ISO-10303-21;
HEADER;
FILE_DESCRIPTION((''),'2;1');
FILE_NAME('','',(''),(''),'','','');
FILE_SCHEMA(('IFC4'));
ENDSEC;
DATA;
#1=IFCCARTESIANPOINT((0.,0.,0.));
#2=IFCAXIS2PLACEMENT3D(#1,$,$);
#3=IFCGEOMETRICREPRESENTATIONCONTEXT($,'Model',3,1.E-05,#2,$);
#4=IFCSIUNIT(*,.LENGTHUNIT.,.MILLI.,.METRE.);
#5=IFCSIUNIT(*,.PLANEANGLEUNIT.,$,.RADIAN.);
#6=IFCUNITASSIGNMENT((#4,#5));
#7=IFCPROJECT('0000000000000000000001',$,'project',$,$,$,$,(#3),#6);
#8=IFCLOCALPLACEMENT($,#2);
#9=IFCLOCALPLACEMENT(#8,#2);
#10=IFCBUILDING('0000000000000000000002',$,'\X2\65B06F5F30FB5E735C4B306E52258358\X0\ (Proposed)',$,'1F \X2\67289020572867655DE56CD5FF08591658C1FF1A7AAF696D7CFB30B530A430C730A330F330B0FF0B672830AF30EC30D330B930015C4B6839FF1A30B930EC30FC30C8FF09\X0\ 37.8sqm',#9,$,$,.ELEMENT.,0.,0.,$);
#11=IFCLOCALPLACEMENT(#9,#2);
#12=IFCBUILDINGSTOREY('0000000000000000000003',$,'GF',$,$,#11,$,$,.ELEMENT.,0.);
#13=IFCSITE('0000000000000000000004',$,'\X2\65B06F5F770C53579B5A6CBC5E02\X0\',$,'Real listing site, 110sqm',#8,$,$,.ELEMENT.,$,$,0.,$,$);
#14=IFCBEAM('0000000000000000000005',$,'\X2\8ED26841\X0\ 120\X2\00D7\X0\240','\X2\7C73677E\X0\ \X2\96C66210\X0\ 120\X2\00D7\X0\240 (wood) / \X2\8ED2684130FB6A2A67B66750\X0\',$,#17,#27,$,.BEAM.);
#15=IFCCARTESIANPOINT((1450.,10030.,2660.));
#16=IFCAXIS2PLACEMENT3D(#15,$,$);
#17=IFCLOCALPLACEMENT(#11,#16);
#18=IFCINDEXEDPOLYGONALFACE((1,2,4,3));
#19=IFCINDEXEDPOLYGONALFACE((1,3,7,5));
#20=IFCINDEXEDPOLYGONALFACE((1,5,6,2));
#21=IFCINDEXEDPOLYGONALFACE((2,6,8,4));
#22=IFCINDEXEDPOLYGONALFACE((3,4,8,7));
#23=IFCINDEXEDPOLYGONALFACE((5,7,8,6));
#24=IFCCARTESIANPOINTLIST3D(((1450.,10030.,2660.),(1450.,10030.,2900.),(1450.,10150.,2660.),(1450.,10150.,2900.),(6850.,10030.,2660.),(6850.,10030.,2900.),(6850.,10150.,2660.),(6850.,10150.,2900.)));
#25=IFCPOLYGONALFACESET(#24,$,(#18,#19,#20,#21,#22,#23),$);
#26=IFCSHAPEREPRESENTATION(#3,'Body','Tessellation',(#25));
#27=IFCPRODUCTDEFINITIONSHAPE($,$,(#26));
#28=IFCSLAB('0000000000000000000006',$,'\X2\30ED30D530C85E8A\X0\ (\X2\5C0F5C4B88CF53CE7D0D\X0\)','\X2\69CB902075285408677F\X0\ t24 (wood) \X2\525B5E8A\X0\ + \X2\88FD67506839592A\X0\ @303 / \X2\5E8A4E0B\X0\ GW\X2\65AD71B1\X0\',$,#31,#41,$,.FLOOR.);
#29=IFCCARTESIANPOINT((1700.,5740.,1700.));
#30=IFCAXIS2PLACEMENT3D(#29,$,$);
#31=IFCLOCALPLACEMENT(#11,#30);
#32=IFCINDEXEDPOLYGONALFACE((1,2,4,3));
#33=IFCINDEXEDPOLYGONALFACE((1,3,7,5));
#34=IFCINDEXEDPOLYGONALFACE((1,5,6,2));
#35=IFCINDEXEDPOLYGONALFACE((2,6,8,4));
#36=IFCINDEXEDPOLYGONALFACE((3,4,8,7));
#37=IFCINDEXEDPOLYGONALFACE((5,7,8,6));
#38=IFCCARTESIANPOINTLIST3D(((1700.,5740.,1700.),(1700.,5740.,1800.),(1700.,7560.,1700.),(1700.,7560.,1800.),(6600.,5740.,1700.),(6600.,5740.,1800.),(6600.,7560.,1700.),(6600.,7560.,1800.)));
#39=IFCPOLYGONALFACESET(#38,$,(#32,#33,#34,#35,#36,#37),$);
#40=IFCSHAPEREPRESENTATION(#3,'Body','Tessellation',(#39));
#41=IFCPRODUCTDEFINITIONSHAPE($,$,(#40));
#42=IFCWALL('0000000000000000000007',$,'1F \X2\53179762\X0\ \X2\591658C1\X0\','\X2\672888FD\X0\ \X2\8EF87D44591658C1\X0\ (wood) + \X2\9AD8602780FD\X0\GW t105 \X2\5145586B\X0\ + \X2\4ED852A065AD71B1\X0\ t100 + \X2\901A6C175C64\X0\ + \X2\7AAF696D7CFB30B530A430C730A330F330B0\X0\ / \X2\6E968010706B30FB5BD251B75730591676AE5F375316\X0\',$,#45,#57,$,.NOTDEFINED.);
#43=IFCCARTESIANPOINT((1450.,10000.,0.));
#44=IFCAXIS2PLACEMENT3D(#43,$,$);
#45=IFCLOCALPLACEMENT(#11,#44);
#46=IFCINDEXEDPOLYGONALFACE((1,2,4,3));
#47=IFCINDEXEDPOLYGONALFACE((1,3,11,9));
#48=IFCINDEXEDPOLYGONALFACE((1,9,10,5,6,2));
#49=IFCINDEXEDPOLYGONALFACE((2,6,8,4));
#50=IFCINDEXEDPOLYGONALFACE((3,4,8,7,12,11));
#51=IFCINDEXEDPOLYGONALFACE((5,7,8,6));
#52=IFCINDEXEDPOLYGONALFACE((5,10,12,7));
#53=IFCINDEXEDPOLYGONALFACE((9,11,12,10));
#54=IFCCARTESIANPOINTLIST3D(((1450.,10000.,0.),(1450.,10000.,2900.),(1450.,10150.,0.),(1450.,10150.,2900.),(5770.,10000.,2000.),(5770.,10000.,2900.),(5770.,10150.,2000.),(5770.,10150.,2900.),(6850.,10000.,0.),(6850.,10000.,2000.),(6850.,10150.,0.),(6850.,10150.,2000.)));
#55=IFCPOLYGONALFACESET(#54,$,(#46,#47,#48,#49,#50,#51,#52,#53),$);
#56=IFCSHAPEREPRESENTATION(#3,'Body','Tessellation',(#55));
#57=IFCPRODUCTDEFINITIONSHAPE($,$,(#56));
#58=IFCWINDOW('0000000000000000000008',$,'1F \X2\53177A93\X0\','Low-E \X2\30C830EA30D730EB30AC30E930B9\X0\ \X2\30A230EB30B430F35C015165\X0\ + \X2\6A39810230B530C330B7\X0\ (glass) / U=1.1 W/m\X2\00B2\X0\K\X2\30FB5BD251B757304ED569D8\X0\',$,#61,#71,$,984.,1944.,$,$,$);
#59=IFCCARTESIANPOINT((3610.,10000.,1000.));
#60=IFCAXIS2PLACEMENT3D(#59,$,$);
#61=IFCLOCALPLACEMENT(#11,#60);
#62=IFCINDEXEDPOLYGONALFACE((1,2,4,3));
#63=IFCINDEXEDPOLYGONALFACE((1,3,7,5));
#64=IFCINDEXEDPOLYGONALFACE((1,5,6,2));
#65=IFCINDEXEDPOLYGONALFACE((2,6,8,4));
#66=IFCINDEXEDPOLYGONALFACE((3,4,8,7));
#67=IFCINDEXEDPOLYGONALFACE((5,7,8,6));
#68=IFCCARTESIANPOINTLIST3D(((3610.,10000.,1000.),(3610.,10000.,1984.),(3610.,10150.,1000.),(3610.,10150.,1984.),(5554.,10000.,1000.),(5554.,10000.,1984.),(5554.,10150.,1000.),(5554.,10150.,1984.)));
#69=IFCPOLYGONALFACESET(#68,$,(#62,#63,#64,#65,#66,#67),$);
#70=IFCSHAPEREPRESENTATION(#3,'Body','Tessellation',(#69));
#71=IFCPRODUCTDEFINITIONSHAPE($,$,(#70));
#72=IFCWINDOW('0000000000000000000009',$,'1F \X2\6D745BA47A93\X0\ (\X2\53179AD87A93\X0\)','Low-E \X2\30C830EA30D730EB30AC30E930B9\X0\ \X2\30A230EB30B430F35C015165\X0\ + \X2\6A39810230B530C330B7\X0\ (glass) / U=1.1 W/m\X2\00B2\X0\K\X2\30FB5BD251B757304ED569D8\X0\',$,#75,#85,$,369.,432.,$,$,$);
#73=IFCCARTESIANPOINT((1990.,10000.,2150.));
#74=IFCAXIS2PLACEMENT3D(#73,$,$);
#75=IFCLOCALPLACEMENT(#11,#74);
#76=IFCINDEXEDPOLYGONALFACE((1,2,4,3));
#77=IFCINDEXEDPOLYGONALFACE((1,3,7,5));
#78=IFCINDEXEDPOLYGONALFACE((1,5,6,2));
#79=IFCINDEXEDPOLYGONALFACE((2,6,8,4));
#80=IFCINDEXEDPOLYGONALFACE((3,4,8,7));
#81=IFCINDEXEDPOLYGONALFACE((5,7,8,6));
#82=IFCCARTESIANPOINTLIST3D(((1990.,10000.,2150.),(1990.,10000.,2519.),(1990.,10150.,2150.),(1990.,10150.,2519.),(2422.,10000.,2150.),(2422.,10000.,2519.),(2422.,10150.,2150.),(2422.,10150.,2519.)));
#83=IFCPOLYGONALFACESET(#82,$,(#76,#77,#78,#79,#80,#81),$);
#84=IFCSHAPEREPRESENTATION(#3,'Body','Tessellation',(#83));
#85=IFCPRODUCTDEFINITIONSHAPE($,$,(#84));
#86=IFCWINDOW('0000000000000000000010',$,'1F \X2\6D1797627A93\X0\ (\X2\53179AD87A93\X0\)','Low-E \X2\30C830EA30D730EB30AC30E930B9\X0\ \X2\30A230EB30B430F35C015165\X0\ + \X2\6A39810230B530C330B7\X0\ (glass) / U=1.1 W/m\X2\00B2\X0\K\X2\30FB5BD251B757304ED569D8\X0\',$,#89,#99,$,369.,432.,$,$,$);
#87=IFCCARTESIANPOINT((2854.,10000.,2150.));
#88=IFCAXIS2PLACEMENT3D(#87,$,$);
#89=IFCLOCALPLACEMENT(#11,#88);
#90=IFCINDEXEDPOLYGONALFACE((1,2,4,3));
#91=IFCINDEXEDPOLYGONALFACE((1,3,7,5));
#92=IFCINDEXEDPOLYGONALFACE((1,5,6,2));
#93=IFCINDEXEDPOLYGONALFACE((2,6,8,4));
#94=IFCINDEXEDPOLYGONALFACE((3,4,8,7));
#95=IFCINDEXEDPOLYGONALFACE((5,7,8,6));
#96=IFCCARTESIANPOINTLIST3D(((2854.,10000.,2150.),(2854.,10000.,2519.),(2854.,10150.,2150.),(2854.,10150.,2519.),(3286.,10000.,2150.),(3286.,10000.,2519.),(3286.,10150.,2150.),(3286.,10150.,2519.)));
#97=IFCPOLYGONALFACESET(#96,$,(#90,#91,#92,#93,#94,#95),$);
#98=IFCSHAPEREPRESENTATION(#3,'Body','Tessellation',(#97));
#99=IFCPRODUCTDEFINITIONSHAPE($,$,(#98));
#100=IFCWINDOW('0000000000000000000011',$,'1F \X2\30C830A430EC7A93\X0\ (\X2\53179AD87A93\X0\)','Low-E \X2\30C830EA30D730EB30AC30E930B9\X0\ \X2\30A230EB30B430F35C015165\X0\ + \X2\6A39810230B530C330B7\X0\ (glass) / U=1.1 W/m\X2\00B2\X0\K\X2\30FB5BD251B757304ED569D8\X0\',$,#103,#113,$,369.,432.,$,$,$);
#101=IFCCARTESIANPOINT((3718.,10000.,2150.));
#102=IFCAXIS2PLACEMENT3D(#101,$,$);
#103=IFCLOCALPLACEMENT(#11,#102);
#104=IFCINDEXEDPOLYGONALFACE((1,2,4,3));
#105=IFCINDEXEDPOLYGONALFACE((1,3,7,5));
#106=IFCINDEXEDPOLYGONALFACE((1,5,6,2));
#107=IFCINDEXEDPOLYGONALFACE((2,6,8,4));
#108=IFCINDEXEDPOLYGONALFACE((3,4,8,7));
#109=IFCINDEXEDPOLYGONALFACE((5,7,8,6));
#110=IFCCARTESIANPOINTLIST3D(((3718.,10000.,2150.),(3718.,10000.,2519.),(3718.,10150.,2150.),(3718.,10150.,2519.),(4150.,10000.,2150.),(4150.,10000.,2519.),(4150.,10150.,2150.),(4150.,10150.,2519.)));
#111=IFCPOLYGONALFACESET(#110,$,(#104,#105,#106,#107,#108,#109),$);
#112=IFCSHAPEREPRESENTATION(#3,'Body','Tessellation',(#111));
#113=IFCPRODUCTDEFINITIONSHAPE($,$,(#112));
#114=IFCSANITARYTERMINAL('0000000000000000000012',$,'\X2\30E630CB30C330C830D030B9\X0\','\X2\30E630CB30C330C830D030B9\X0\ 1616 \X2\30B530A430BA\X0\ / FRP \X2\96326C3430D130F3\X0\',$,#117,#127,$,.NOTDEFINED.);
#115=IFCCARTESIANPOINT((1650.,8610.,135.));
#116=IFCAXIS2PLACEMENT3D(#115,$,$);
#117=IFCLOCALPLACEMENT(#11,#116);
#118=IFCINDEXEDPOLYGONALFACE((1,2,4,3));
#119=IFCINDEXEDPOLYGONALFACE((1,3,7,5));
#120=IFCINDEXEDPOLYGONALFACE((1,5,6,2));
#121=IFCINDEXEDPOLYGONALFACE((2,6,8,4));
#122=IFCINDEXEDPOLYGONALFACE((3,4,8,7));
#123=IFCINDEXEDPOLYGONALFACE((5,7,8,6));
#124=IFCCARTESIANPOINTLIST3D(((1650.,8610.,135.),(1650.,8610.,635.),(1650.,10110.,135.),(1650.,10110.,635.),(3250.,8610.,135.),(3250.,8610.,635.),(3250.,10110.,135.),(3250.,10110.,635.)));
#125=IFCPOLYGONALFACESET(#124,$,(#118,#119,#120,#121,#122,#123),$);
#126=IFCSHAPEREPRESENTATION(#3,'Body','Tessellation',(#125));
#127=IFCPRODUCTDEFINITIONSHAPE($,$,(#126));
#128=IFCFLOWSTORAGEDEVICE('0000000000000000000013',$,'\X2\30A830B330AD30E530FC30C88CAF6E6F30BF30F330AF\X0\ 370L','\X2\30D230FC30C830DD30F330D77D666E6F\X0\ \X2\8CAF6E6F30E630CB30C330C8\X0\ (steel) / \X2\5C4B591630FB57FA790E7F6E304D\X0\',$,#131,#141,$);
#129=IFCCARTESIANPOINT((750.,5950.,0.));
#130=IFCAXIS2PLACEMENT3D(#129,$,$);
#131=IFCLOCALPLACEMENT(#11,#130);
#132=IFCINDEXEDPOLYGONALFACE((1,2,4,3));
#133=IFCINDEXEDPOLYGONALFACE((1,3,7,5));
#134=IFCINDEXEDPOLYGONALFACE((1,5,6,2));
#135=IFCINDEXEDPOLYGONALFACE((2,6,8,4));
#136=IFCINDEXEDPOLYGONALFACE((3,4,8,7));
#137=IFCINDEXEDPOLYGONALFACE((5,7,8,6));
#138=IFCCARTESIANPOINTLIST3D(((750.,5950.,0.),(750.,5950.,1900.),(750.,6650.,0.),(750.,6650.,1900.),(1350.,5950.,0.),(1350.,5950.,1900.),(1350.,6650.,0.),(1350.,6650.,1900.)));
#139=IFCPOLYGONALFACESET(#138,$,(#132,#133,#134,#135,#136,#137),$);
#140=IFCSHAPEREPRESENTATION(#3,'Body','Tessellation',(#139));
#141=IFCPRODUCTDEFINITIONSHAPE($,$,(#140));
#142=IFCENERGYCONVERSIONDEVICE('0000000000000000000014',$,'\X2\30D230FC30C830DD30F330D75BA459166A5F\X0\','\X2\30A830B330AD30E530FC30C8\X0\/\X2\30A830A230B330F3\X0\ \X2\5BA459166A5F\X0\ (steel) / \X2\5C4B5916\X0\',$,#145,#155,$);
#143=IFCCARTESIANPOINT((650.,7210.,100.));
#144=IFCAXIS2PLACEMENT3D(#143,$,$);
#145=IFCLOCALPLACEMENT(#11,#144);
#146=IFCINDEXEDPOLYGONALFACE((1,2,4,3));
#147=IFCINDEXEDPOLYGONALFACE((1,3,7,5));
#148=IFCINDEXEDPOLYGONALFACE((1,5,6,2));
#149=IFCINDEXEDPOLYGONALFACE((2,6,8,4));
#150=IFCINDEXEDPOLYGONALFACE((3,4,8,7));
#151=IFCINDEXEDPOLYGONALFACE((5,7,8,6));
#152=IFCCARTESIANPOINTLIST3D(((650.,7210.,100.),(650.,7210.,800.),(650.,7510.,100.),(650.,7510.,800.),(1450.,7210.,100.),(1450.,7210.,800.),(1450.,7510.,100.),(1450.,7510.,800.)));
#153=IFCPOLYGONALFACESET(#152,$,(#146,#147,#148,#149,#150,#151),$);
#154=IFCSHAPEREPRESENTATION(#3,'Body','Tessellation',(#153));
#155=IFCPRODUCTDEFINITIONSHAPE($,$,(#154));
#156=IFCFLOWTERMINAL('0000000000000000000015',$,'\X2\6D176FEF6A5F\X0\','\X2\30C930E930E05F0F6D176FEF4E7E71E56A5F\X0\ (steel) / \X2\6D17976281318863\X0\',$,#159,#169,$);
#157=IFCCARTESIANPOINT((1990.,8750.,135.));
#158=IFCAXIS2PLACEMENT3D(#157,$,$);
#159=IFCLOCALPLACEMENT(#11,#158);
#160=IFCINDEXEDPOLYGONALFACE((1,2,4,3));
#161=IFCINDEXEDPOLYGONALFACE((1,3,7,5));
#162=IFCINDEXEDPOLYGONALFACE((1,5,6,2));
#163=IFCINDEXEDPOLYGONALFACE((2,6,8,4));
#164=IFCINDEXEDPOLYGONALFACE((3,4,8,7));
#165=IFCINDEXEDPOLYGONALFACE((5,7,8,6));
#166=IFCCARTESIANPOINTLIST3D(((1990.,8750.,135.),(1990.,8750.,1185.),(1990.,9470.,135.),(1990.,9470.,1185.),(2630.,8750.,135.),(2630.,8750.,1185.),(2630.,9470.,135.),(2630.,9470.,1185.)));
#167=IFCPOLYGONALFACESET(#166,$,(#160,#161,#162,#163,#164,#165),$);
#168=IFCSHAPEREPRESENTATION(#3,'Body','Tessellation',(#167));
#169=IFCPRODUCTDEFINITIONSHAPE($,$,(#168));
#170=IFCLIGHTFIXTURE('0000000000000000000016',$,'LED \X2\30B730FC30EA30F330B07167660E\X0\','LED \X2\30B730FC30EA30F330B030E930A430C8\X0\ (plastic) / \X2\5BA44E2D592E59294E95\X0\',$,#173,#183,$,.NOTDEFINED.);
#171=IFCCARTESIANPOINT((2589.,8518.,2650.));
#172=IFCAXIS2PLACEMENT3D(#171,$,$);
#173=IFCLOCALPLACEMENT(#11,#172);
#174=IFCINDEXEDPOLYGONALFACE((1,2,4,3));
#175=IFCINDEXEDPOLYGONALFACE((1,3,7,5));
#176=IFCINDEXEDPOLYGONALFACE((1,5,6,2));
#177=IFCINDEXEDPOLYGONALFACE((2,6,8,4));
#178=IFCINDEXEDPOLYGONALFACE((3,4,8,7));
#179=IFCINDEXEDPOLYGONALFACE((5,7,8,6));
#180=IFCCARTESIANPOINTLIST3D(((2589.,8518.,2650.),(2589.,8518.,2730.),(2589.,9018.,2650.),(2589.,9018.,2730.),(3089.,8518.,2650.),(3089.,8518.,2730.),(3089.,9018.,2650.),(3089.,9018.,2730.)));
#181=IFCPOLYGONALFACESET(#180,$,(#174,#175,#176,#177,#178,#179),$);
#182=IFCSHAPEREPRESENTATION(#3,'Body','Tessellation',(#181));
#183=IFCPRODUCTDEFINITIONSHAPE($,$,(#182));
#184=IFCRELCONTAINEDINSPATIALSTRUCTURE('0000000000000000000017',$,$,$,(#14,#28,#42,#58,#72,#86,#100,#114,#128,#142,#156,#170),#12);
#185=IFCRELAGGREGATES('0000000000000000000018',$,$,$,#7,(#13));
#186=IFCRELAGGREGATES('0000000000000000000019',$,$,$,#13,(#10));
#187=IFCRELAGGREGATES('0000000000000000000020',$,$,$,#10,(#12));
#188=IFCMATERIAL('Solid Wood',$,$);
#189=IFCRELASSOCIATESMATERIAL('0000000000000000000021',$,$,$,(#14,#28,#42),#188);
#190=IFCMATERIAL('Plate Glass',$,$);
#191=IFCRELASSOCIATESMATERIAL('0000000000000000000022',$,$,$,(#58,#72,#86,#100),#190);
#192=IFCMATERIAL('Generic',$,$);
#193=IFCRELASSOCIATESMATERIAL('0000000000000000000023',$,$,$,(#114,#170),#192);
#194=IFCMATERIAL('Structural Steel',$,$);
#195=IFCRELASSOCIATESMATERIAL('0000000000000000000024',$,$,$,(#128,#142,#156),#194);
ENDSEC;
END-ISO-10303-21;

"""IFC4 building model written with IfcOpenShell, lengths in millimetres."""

from ifc_helpers import new_model, si_unit, frame, frame_2d, origin, place, context, project, spatial, rectangle, extrude, material, element, fill, save


model = new_model("IFC4")

# Units and contexts
model_context = context("Model", 3, precision=1e-05, world=origin())
ifc_project = project(units=[si_unit("LENGTHUNIT", "METRE", prefix="MILLI"), si_unit("PLANEANGLEUNIT", "RADIAN")], contexts=[model_context])

# Site, building, storey
site_placement = place(None, origin())
site = spatial("IfcSite", under=ifc_project, at=site_placement, Name="新潟県南魚沼市", ObjectType="Real listing site, 110sqm", CompositionType="ELEMENT", RefElevation=0.0)
building_placement = place(site_placement, origin())
building = spatial("IfcBuilding", under=site, at=building_placement, Name="新潟・平屋の別荘 (Proposed)", ObjectType="1F 木造在来工法（外壁：窯業系サイディング＋木クレビス、屋根：スレート） 37.8sqm", CompositionType="ELEMENT", ElevationOfRefHeight=0.0, ElevationOfTerrain=0.0)
storey_placement = place(building_placement, origin())
storey = spatial("IfcBuildingStorey", under=building, at=storey_placement, Name="GF", CompositionType="ELEMENT", Elevation=0.0)

# Shared definitions
ifc_material_1 = material(Name="Solid Wood")

# Beam
beam_1_placement = place(storey_placement, frame((1450.0, 10030.0, 2660.0)))
element("IfcBeam", 1, at=beam_1_placement, inside=storey, material=ifc_material_1, Name="軒桁 120×240", Description="米松 集成 120×240 (wood) / 軒桁・横架材", PredefinedType="BEAM", context=model_context, shape_type="SweptSolid", body=[
    extrude(rectangle(XDim=5400.0, YDim=120.0, at=frame_2d((2700.0, 60.0))), frame((1450.0, 10030.0, 2660.0)), (0.0, 0.0, 1.0), 240.0),
])

# Slab
slab_placement = place(storey_placement, frame((1700.0, 5740.0, 1700.0)))
element("IfcSlab", 2, at=slab_placement, inside=storey, material=ifc_material_1, Name="ロフト床 (小屋裏収納)", Description="構造用合板 t24 (wood) 剛床 + 製材根太 @303 / 床下 GW断熱", PredefinedType="FLOOR", context=model_context, shape_type="SweptSolid", body=[
    extrude(rectangle(XDim=4900.0, YDim=1820.0, at=frame_2d((2450.0, 910.0))), frame((1700.0, 5740.0, 1700.0)), (0.0, 0.0, 1.0), 100.0),
])

# Wall, openings, windows
wall_1_placement = place(storey_placement, frame((1450.0, 10000.0, 0.0)))
wall_1 = element("IfcWall", 3, at=wall_1_placement, inside=storey, material=ifc_material_1, Name="1F 北面 外壁", Description="木製 軸組外壁 (wood) + 高性能GW t105 充填 + 付加断熱 t100 + 通気層 + 窯業系サイディング / 準耐火・寒冷地外皮強化", PredefinedType="NOTDEFINED", context=model_context, shape_type="SweptSolid", body=[
    extrude(rectangle(XDim=5400.0, YDim=150.0, at=frame_2d((2700.0, 75.0))), frame((1450.0, 10000.0, 0.0)), (0.0, 0.0, 1.0), 2900.0),
])
opening_1_placement = place(storey_placement, frame((3610.0, 10000.0, 1000.0)))
opening_1 = element("IfcOpeningElement", 4, at=opening_1_placement, cuts=wall_1, PredefinedType="NOTDEFINED", context=model_context, shape_type="SweptSolid", body=[
    extrude(rectangle(XDim=1944.0, YDim=150.0, at=frame_2d((972.0, 75.0))), frame((3610.0, 10000.0, 1000.0)), (0.0, 0.0, 1.0), 984.0),
])
opening_2_placement = place(storey_placement, frame((1990.0, 10000.0, 2150.0)))
opening_2 = element("IfcOpeningElement", 5, at=opening_2_placement, cuts=wall_1, PredefinedType="NOTDEFINED", context=model_context, shape_type="SweptSolid", body=[
    extrude(rectangle(XDim=432.0, YDim=150.0, at=frame_2d((216.0, 75.0))), frame((1990.0, 10000.0, 2150.0)), (0.0, 0.0, 1.0), 369.0),
])
opening_3_placement = place(storey_placement, frame((2854.0, 10000.0, 2150.0)))
opening_3 = element("IfcOpeningElement", 6, at=opening_3_placement, cuts=wall_1, PredefinedType="NOTDEFINED", context=model_context, shape_type="SweptSolid", body=[
    extrude(rectangle(XDim=432.0, YDim=150.0, at=frame_2d((216.0, 75.0))), frame((2854.0, 10000.0, 2150.0)), (0.0, 0.0, 1.0), 369.0),
])
opening_4_placement = place(storey_placement, frame((3718.0, 10000.0, 2150.0)))
opening_4 = element("IfcOpeningElement", 7, at=opening_4_placement, cuts=wall_1, PredefinedType="NOTDEFINED", context=model_context, shape_type="SweptSolid", body=[
    extrude(rectangle(XDim=432.0, YDim=150.0, at=frame_2d((216.0, 75.0))), frame((3718.0, 10000.0, 2150.0)), (0.0, 0.0, 1.0), 369.0),
])
ifc_material_2 = material(Name="Plate Glass")
window_1_placement = place(storey_placement, frame((3610.0, 10000.0, 1000.0)))
window_1 = element("IfcWindow", 8, at=window_1_placement, inside=storey, material=ifc_material_2, Name="1F 北窓", Description="Low-E トリプルガラス アルゴン封入 + 樹脂サッシ (glass) / U=1.1 W/m²K・寒冷地仕様", OverallHeight=984.0, OverallWidth=1944.0, context=model_context, shape_type="SweptSolid", body=[
    extrude(rectangle(XDim=1944.0, YDim=150.0, at=frame_2d((972.0, 75.0))), frame((3610.0, 10000.0, 1000.0)), (0.0, 0.0, 1.0), 984.0),
])
fill(opening_1, window_1)
window_2_placement = place(storey_placement, frame((1990.0, 10000.0, 2150.0)))
window_2 = element("IfcWindow", 9, at=window_2_placement, inside=storey, material=ifc_material_2, Name="1F 浴室窓 (北高窓)", Description="Low-E トリプルガラス アルゴン封入 + 樹脂サッシ (glass) / U=1.1 W/m²K・寒冷地仕様", OverallHeight=369.0, OverallWidth=432.0, context=model_context, shape_type="SweptSolid", body=[
    extrude(rectangle(XDim=432.0, YDim=150.0, at=frame_2d((216.0, 75.0))), frame((1990.0, 10000.0, 2150.0)), (0.0, 0.0, 1.0), 369.0),
])
fill(opening_2, window_2)
window_3_placement = place(storey_placement, frame((2854.0, 10000.0, 2150.0)))
window_3 = element("IfcWindow", 10, at=window_3_placement, inside=storey, material=ifc_material_2, Name="1F 洗面窓 (北高窓)", Description="Low-E トリプルガラス アルゴン封入 + 樹脂サッシ (glass) / U=1.1 W/m²K・寒冷地仕様", OverallHeight=369.0, OverallWidth=432.0, context=model_context, shape_type="SweptSolid", body=[
    extrude(rectangle(XDim=432.0, YDim=150.0, at=frame_2d((216.0, 75.0))), frame((2854.0, 10000.0, 2150.0)), (0.0, 0.0, 1.0), 369.0),
])
fill(opening_3, window_3)
window_4_placement = place(storey_placement, frame((3718.0, 10000.0, 2150.0)))
window_4 = element("IfcWindow", 11, at=window_4_placement, inside=storey, material=ifc_material_2, Name="1F トイレ窓 (北高窓)", Description="Low-E トリプルガラス アルゴン封入 + 樹脂サッシ (glass) / U=1.1 W/m²K・寒冷地仕様", OverallHeight=369.0, OverallWidth=432.0, context=model_context, shape_type="SweptSolid", body=[
    extrude(rectangle(XDim=432.0, YDim=150.0, at=frame_2d((216.0, 75.0))), frame((3718.0, 10000.0, 2150.0)), (0.0, 0.0, 1.0), 369.0),
])
fill(opening_4, window_4)

# Sanitary terminal
ifc_material_3 = material(Name="Generic")
sanitary_terminal_placement = place(storey_placement, frame((1650.0, 8610.0, 135.0)))
element("IfcSanitaryTerminal", 12, at=sanitary_terminal_placement, inside=storey, material=ifc_material_3, Name="ユニットバス", Description="ユニットバス 1616 サイズ / FRP 防水パン", PredefinedType="NOTDEFINED", context=model_context, shape_type="SweptSolid", body=[
    extrude(rectangle(XDim=1600.0, YDim=1500.0, at=frame_2d((800.0, 750.0))), frame((1650.0, 8610.0, 135.0)), (0.0, 0.0, 1.0), 500.0),
])

# Flow storage device
ifc_material_4 = material(Name="Structural Steel")
flow_storage_device_placement = place(storey_placement, frame((750.0, 5950.0, 0.0)))
element("IfcFlowStorageDevice", 13, at=flow_storage_device_placement, inside=storey, material=ifc_material_4, Name="エコキュート貯湯タンク 370L", Description="ヒートポンプ給湯 貯湯ユニット (steel) / 屋外・基礎置き", context=model_context, shape_type="SweptSolid", body=[
    extrude(rectangle(XDim=600.0, YDim=700.0, at=frame_2d((300.0, 350.0))), frame((750.0, 5950.0, 0.0)), (0.0, 0.0, 1.0), 1900.0),
])

# Energy conversion device
energy_conversion_device_placement = place(storey_placement, frame((650.0, 7210.0, 100.0)))
element("IfcEnergyConversionDevice", 14, at=energy_conversion_device_placement, inside=storey, material=ifc_material_4, Name="ヒートポンプ室外機", Description="エコキュート/エアコン 室外機 (steel) / 屋外", context=model_context, shape_type="SweptSolid", body=[
    extrude(rectangle(XDim=800.0, YDim=300.0, at=frame_2d((400.0, 150.0))), frame((650.0, 7210.0, 100.0)), (0.0, 0.0, 1.0), 700.0),
])

# Flow terminal
flow_terminal_placement = place(storey_placement, frame((1990.0, 8750.0, 135.0)))
element("IfcFlowTerminal", 15, at=flow_terminal_placement, inside=storey, material=ifc_material_4, Name="洗濯機", Description="ドラム式洗濯乾燥機 (steel) / 洗面脱衣", context=model_context, shape_type="SweptSolid", body=[
    extrude(rectangle(XDim=640.0, YDim=720.0, at=frame_2d((320.0, 360.0))), frame((1990.0, 8750.0, 135.0)), (0.0, 0.0, 1.0), 1050.0),
])

# Light fixture
light_fixture_placement = place(storey_placement, frame((2589.0, 8518.0, 2650.0)))
element("IfcLightFixture", 16, at=light_fixture_placement, inside=storey, material=ifc_material_3, Name="LED シーリング照明", Description="LED シーリングライト (plastic) / 室中央天井", PredefinedType="NOTDEFINED", context=model_context, shape_type="SweptSolid", body=[
    extrude(rectangle(XDim=500.0, YDim=500.0, at=frame_2d((250.0, 250.0))), frame((2589.0, 8518.0, 2650.0)), (0.0, 0.0, 1.0), 80.0),
])

save(model, "model.ifc")
